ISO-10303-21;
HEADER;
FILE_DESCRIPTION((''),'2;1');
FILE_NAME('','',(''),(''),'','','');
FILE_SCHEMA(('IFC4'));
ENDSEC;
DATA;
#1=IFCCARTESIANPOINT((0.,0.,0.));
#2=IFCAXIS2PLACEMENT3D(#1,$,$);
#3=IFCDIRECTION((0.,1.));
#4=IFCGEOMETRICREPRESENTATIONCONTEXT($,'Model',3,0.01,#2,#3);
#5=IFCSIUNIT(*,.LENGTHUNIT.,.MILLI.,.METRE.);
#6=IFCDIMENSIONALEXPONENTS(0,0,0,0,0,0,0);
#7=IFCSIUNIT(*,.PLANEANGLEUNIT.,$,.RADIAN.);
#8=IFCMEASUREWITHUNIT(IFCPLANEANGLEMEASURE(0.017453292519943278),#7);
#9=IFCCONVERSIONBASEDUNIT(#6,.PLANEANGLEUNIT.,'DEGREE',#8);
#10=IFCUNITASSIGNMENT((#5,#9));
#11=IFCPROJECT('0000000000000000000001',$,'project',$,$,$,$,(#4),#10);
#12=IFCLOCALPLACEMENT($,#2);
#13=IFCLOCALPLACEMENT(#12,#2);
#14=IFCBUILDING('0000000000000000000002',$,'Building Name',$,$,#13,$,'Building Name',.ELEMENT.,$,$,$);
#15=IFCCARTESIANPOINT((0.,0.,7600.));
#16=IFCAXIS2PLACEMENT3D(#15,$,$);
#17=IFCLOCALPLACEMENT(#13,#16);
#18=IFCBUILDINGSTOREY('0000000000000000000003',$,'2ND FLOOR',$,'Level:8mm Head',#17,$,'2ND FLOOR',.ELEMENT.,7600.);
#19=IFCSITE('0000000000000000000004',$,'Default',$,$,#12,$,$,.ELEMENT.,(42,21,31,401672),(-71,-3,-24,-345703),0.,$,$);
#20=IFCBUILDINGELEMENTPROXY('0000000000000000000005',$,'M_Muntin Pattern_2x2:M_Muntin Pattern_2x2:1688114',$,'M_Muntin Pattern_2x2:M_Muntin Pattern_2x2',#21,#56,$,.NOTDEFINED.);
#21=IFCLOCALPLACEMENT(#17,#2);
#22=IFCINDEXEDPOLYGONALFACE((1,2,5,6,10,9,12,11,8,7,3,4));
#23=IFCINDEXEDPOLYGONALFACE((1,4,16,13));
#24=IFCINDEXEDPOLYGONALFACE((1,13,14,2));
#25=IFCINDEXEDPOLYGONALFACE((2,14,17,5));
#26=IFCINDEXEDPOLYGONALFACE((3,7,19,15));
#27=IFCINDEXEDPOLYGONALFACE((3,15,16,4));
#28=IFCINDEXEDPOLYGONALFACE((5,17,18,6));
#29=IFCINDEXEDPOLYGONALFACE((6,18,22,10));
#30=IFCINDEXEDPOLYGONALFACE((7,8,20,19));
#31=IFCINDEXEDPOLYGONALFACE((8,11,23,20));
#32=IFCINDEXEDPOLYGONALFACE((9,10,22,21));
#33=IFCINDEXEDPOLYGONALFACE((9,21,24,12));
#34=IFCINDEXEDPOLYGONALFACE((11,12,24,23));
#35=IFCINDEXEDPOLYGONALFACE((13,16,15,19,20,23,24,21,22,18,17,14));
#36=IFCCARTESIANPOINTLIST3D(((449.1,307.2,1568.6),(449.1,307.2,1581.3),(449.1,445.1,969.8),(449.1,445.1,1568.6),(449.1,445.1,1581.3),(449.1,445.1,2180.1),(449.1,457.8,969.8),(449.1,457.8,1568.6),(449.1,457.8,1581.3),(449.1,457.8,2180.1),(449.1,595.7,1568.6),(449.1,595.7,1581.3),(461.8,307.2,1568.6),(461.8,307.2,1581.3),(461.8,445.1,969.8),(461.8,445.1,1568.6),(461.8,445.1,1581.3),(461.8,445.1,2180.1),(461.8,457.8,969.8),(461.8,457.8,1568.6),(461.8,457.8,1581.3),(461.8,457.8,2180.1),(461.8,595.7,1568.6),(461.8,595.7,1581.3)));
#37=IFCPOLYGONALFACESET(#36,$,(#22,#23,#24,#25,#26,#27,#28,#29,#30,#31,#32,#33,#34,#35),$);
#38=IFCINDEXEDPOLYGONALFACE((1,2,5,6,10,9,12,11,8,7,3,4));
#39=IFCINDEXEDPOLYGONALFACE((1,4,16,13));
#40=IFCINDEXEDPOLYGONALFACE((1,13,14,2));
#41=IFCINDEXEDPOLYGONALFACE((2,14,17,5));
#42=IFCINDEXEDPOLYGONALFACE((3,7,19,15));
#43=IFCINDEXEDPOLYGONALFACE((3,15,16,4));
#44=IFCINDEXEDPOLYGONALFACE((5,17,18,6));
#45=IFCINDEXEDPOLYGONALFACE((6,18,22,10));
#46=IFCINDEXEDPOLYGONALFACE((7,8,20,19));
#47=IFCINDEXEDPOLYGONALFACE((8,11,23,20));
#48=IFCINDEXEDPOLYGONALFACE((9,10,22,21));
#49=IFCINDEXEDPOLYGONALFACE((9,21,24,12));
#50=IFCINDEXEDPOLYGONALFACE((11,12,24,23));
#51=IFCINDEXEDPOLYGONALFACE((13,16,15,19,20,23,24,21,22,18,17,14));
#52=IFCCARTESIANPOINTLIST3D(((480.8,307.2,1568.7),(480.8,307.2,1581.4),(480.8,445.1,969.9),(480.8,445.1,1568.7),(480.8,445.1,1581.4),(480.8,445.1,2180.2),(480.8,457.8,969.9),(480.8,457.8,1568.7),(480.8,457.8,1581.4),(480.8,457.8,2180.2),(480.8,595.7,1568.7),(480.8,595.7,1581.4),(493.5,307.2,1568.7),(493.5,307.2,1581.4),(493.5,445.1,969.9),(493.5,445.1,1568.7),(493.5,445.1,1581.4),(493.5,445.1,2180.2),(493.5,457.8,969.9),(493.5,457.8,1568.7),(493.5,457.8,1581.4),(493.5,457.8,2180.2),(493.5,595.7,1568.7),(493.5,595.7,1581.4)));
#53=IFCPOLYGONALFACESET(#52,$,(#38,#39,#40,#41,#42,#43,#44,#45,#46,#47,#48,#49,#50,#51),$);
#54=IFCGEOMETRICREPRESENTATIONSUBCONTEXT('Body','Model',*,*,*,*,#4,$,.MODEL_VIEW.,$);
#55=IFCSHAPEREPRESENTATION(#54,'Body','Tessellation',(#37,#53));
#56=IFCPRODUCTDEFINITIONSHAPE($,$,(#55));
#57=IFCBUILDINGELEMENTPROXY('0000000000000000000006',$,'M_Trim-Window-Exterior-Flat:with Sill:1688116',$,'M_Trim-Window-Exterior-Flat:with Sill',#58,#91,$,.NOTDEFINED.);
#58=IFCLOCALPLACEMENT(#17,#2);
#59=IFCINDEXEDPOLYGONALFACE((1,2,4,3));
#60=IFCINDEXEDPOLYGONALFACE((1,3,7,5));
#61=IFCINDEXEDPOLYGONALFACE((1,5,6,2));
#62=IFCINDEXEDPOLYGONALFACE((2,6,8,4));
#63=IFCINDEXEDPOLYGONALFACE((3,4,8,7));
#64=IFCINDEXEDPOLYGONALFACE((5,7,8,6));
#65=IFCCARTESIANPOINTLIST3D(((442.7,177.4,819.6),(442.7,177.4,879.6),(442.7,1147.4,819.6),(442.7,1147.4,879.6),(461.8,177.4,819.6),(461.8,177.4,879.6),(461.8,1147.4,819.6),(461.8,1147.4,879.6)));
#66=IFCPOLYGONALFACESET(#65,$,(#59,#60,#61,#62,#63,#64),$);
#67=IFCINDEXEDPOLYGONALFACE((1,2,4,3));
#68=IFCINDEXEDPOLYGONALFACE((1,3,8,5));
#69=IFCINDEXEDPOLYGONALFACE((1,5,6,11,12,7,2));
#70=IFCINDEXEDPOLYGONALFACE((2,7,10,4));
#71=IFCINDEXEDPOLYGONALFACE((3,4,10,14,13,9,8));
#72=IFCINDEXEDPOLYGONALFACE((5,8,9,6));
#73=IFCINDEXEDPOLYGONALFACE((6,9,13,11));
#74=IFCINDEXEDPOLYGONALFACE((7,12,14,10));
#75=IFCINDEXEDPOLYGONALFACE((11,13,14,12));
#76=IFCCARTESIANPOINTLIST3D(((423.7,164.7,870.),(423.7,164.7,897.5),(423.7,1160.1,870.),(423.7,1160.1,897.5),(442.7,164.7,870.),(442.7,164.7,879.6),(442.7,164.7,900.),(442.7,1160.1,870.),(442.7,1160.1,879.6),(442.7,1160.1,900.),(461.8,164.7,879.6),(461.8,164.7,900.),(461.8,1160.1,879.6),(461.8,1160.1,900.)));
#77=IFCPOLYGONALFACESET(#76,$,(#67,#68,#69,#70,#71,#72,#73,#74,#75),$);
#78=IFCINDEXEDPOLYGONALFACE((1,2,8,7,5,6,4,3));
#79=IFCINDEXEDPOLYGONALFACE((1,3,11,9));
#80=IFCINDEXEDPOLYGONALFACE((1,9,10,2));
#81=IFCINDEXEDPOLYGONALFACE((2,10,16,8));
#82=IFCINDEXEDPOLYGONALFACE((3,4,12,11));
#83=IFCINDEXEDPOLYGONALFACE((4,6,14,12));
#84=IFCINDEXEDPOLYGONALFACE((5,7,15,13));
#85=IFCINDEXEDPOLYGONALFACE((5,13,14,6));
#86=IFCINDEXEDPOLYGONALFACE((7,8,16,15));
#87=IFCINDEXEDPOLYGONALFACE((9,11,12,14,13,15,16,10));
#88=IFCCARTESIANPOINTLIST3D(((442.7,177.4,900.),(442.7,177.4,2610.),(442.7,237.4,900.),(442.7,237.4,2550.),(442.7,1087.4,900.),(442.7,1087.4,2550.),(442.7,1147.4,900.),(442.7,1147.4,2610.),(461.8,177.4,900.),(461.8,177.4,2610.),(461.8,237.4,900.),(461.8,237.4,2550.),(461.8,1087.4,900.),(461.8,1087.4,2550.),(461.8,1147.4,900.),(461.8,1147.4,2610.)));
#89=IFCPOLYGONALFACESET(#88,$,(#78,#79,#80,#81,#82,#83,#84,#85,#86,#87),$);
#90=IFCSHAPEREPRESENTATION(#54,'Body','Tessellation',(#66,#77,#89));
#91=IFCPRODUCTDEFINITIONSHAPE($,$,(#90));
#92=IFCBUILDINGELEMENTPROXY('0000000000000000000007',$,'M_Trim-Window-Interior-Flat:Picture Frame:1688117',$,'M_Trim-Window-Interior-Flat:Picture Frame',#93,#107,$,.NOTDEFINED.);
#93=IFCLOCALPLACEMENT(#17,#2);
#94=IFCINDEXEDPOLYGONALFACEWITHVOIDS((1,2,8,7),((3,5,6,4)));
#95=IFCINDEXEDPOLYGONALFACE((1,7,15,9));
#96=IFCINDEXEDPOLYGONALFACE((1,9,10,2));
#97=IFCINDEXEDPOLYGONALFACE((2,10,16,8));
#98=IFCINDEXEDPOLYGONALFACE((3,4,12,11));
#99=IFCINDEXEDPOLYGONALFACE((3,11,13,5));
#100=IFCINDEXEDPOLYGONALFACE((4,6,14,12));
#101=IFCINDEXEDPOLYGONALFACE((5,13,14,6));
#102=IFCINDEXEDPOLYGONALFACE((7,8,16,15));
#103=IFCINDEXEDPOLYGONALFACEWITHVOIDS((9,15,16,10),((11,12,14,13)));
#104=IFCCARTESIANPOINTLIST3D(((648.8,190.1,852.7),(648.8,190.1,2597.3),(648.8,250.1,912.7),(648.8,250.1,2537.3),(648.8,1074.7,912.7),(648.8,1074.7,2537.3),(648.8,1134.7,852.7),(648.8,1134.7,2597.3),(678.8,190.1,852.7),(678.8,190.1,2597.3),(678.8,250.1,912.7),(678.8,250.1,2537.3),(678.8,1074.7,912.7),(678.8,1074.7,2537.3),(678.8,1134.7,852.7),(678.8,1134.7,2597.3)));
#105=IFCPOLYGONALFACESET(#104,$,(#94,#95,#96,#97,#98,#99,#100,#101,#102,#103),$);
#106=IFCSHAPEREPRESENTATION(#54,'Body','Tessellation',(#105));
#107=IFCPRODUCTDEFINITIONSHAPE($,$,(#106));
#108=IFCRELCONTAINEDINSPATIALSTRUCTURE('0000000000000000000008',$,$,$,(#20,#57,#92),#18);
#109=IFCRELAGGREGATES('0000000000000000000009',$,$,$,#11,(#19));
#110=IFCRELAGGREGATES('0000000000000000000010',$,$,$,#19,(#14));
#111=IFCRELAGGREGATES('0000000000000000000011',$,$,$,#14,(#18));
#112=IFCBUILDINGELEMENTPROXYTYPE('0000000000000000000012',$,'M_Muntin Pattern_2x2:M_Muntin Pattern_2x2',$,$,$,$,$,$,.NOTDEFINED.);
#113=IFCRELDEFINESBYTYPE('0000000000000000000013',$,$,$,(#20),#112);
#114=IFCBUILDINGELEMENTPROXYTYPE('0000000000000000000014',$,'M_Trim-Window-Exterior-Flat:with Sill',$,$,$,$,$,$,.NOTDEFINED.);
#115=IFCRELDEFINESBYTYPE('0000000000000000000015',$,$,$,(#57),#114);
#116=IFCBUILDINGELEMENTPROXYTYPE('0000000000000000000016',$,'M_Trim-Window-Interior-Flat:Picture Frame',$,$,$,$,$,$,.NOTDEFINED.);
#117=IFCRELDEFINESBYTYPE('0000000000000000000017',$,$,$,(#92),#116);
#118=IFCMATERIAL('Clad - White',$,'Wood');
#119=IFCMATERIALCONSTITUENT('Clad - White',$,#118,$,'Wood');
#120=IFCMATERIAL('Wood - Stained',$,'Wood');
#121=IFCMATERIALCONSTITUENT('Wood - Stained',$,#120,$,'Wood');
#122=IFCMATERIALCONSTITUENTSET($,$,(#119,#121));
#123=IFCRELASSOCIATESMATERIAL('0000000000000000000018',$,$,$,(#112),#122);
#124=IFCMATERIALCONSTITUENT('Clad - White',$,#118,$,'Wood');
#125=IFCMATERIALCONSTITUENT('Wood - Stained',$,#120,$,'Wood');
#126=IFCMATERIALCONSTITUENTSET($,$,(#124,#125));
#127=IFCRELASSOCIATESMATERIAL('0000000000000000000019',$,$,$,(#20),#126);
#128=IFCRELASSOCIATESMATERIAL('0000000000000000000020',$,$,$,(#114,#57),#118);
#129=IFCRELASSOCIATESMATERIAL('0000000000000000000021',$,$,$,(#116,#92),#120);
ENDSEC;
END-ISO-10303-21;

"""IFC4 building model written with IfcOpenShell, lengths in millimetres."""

from ifc_helpers import new_model, entity, si_unit, converted_unit, direction, frame, origin, place, context, subcontext, project, spatial, indexed_curve, outline, extrude, source, transform, mapped, material, constituent, constituent_set, type_object, type_shapes, element, save


model = new_model("IFC4")

# Units and contexts
model_context = context("Model", 3, precision=0.01, world=origin(), true_north=direction((0.0, 1.0)))
body_context = subcontext(model_context, "Body", "Model", "MODEL_VIEW")
ifc_project = project(units=[si_unit("LENGTHUNIT", "METRE", prefix="MILLI"), converted_unit("PLANEANGLEUNIT", "DEGREE", entity("IfcPlaneAngleMeasure", 0.017453292519943278), si_unit("PLANEANGLEUNIT", "RADIAN"), dimensions=[0, 0, 0, 0, 0, 0, 0])], contexts=[model_context])

# Site, building, storey
site_placement = place(None, origin())
site = spatial("IfcSite", under=ifc_project, at=site_placement, Name="Default", CompositionType="ELEMENT", RefLatitude=(42, 21, 31, 401672), RefLongitude=(-71, -3, -24, -345703), RefElevation=0.0)
building_placement = place(site_placement, origin())
building = spatial("IfcBuilding", under=site, at=building_placement, Name="Building Name", LongName="Building Name", CompositionType="ELEMENT")
storey_placement = place(building_placement, frame((0.0, 0.0, 7600.0)))
storey = spatial("IfcBuildingStorey", under=building, at=storey_placement, Name="2ND FLOOR", ObjectType="Level:8mm Head", LongName="2ND FLOOR", CompositionType="ELEMENT", Elevation=7600.0)

# Building element proxies
ifc_material_1 = material(Name="Clad - White", Category="Wood")
ifc_material_2 = material(Name="Wood - Stained", Category="Wood")
ifc_constituent_1 = constituent(ifc_material_1, Name="Clad - White", Category="Wood")
ifc_constituent_2 = constituent(ifc_material_2, Name="Wood - Stained", Category="Wood")
ifc_constituent_set_1 = constituent_set(constituents=[ifc_constituent_1, ifc_constituent_2])
ifc_constituent_3 = constituent(ifc_material_1, Name="Clad - White", Category="Wood")
ifc_constituent_4 = constituent(ifc_material_2, Name="Wood - Stained", Category="Wood")
ifc_constituent_set_2 = constituent_set(constituents=[ifc_constituent_3, ifc_constituent_4])
building_element_proxy_type_1 = type_object("IfcBuildingElementProxyType", Name="M_Muntin Pattern_2x2:M_Muntin Pattern_2x2", PredefinedType="NOTDEFINED", material=ifc_constituent_set_2)
shared_shape_1 = source(origin(), body_context, "Body", "SweptSolid", [
    extrude(outline(indexed_curve([(6.4, -6.4), (605.1, -6.4), (605.1, 6.3), (6.4, 6.3), (6.4, 144.2), (-6.3, 144.2), (-6.3, 6.3), (-605.2, 6.3), (-605.2, -6.4), (-6.3, -6.4), (-6.3, -144.2), (6.4, -144.2), (6.4, -6.4)], self_intersect=False)), frame((0.0, 9.5, 605.1), z_axis=(0.0, 1.0, 0.0), x_axis=(0.0, 0.0, 1.0)), (0.0, 0.0, 1.0), 12.7),
    extrude(outline(indexed_curve([(6.4, -6.4), (605.2, -6.4), (605.2, 6.3), (6.4, 6.3), (6.4, 144.2), (-6.3, 144.2), (-6.3, 6.3), (-605.2, 6.3), (-605.2, -6.4), (-6.3, -6.4), (-6.3, -144.2), (6.4, -144.2), (6.4, -6.4)], self_intersect=False)), frame((0.0, -22.2, 605.2), z_axis=(0.0, 1.0, 0.0), x_axis=(0.0, 0.0, 1.0)), (0.0, 0.0, 1.0), 12.7),
])
type_shapes(building_element_proxy_type_1, [shared_shape_1])
proxy_1_placement = place(storey_placement, frame((471.3, 451.5, 969.9), z_axis=(0.0, 0.0, 1.0), x_axis=(0.0, 1.0, 0.0)))
element("IfcBuildingElementProxy", 1, at=proxy_1_placement, inside=storey, type_object=building_element_proxy_type_1, material=ifc_constituent_set_1, Name="M_Muntin Pattern_2x2:M_Muntin Pattern_2x2:1688114", ObjectType="M_Muntin Pattern_2x2:M_Muntin Pattern_2x2", PredefinedType="NOTDEFINED", context=body_context, shape_type="MappedRepresentation", body=[
    mapped(shared_shape_1, transform((0.0, 0.0, 0.0), scale=1.0)),
])
building_element_proxy_type_2 = type_object("IfcBuildingElementProxyType", Name="M_Trim-Window-Exterior-Flat:with Sill", PredefinedType="NOTDEFINED", material=ifc_material_1)
shared_shape_2 = source(origin(), body_context, "Body", "SweptSolid", [
    extrude(outline(indexed_curve([(-485.0, -30.0), (485.0, -30.0), (485.0, 30.0), (-485.0, 30.0), (-485.0, -30.0)], self_intersect=False)), frame((0.0, -1700.4, 0.0), z_axis=(0.0, 0.0, 1.0), x_axis=(-1.0, 0.0, 0.0)), (0.0, 0.0, 1.0), 19.0),
    extrude(outline(indexed_curve([(-19.0, -15.2), (0.0, -15.2), (0.0, -5.7), (19.0, -5.7), (19.0, 14.8), (0.0, 14.8), (-19.0, 12.3), (-19.0, -15.2)], self_intersect=False)), frame((-497.7, -1664.8, 19.0), z_axis=(1.0, 0.0, 0.0), x_axis=(0.0, 0.0, -1.0)), (0.0, 0.0, 1.0), 995.4),
    extrude(outline(indexed_curve([(-870.0, -485.0), (840.0, -485.0), (840.0, -425.0), (-810.0, -425.0), (-810.0, 425.0), (840.0, 425.0), (840.0, 485.0), (-870.0, 485.0), (-870.0, -485.0)], self_intersect=False)), frame((0.0, -810.0, 0.0), z_axis=(0.0, 0.0, 1.0), x_axis=(0.0, -1.0, 0.0)), (0.0, 0.0, 1.0), 19.0),
])
type_shapes(building_element_proxy_type_2, [shared_shape_2])
proxy_2_placement = place(storey_placement, frame((461.8, 662.4, 2550.0), z_axis=(-1.0, 0.0, 0.0), x_axis=(0.0, -1.0, 0.0)))
element("IfcBuildingElementProxy", 2, at=proxy_2_placement, inside=storey, type_object=building_element_proxy_type_2, material=ifc_material_1, Name="M_Trim-Window-Exterior-Flat:with Sill:1688116", ObjectType="M_Trim-Window-Exterior-Flat:with Sill", PredefinedType="NOTDEFINED", context=body_context, shape_type="MappedRepresentation", body=[
    mapped(shared_shape_2, transform((0.0, 0.0, 0.0), scale=1.0)),
])
building_element_proxy_type_3 = type_object("IfcBuildingElementProxyType", Name="M_Trim-Window-Interior-Flat:Picture Frame", PredefinedType="NOTDEFINED", material=ifc_material_2)
shared_shape_3 = source(origin(), body_context, "Body", "SweptSolid", [
    extrude(outline(indexed_curve([(-472.3, -872.3), (472.3, -872.3), (472.3, 872.3), (-472.3, 872.3), (-472.3, -872.3)], self_intersect=False), holes=[indexed_curve([(-412.3, -812.3), (-412.3, 812.3), (412.3, 812.3), (412.3, -812.3), (-412.3, -812.3)], self_intersect=False)]), frame((0.0, -825.0, 0.0), z_axis=(0.0, 0.0, 1.0), x_axis=(-1.0, 0.0, 0.0)), (0.0, 0.0, 1.0), 30.0),
])
type_shapes(building_element_proxy_type_3, [shared_shape_3])
proxy_3_placement = place(storey_placement, frame((648.8, 662.4, 2550.0), z_axis=(1.0, 0.0, 0.0), x_axis=(0.0, 1.0, 0.0)))
element("IfcBuildingElementProxy", 3, at=proxy_3_placement, inside=storey, type_object=building_element_proxy_type_3, material=ifc_material_2, Name="M_Trim-Window-Interior-Flat:Picture Frame:1688117", ObjectType="M_Trim-Window-Interior-Flat:Picture Frame", PredefinedType="NOTDEFINED", context=body_context, shape_type="MappedRepresentation", body=[
    mapped(shared_shape_3, transform((0.0, 0.0, 0.0), scale=1.0)),
])

save(model, "model.ifc")
